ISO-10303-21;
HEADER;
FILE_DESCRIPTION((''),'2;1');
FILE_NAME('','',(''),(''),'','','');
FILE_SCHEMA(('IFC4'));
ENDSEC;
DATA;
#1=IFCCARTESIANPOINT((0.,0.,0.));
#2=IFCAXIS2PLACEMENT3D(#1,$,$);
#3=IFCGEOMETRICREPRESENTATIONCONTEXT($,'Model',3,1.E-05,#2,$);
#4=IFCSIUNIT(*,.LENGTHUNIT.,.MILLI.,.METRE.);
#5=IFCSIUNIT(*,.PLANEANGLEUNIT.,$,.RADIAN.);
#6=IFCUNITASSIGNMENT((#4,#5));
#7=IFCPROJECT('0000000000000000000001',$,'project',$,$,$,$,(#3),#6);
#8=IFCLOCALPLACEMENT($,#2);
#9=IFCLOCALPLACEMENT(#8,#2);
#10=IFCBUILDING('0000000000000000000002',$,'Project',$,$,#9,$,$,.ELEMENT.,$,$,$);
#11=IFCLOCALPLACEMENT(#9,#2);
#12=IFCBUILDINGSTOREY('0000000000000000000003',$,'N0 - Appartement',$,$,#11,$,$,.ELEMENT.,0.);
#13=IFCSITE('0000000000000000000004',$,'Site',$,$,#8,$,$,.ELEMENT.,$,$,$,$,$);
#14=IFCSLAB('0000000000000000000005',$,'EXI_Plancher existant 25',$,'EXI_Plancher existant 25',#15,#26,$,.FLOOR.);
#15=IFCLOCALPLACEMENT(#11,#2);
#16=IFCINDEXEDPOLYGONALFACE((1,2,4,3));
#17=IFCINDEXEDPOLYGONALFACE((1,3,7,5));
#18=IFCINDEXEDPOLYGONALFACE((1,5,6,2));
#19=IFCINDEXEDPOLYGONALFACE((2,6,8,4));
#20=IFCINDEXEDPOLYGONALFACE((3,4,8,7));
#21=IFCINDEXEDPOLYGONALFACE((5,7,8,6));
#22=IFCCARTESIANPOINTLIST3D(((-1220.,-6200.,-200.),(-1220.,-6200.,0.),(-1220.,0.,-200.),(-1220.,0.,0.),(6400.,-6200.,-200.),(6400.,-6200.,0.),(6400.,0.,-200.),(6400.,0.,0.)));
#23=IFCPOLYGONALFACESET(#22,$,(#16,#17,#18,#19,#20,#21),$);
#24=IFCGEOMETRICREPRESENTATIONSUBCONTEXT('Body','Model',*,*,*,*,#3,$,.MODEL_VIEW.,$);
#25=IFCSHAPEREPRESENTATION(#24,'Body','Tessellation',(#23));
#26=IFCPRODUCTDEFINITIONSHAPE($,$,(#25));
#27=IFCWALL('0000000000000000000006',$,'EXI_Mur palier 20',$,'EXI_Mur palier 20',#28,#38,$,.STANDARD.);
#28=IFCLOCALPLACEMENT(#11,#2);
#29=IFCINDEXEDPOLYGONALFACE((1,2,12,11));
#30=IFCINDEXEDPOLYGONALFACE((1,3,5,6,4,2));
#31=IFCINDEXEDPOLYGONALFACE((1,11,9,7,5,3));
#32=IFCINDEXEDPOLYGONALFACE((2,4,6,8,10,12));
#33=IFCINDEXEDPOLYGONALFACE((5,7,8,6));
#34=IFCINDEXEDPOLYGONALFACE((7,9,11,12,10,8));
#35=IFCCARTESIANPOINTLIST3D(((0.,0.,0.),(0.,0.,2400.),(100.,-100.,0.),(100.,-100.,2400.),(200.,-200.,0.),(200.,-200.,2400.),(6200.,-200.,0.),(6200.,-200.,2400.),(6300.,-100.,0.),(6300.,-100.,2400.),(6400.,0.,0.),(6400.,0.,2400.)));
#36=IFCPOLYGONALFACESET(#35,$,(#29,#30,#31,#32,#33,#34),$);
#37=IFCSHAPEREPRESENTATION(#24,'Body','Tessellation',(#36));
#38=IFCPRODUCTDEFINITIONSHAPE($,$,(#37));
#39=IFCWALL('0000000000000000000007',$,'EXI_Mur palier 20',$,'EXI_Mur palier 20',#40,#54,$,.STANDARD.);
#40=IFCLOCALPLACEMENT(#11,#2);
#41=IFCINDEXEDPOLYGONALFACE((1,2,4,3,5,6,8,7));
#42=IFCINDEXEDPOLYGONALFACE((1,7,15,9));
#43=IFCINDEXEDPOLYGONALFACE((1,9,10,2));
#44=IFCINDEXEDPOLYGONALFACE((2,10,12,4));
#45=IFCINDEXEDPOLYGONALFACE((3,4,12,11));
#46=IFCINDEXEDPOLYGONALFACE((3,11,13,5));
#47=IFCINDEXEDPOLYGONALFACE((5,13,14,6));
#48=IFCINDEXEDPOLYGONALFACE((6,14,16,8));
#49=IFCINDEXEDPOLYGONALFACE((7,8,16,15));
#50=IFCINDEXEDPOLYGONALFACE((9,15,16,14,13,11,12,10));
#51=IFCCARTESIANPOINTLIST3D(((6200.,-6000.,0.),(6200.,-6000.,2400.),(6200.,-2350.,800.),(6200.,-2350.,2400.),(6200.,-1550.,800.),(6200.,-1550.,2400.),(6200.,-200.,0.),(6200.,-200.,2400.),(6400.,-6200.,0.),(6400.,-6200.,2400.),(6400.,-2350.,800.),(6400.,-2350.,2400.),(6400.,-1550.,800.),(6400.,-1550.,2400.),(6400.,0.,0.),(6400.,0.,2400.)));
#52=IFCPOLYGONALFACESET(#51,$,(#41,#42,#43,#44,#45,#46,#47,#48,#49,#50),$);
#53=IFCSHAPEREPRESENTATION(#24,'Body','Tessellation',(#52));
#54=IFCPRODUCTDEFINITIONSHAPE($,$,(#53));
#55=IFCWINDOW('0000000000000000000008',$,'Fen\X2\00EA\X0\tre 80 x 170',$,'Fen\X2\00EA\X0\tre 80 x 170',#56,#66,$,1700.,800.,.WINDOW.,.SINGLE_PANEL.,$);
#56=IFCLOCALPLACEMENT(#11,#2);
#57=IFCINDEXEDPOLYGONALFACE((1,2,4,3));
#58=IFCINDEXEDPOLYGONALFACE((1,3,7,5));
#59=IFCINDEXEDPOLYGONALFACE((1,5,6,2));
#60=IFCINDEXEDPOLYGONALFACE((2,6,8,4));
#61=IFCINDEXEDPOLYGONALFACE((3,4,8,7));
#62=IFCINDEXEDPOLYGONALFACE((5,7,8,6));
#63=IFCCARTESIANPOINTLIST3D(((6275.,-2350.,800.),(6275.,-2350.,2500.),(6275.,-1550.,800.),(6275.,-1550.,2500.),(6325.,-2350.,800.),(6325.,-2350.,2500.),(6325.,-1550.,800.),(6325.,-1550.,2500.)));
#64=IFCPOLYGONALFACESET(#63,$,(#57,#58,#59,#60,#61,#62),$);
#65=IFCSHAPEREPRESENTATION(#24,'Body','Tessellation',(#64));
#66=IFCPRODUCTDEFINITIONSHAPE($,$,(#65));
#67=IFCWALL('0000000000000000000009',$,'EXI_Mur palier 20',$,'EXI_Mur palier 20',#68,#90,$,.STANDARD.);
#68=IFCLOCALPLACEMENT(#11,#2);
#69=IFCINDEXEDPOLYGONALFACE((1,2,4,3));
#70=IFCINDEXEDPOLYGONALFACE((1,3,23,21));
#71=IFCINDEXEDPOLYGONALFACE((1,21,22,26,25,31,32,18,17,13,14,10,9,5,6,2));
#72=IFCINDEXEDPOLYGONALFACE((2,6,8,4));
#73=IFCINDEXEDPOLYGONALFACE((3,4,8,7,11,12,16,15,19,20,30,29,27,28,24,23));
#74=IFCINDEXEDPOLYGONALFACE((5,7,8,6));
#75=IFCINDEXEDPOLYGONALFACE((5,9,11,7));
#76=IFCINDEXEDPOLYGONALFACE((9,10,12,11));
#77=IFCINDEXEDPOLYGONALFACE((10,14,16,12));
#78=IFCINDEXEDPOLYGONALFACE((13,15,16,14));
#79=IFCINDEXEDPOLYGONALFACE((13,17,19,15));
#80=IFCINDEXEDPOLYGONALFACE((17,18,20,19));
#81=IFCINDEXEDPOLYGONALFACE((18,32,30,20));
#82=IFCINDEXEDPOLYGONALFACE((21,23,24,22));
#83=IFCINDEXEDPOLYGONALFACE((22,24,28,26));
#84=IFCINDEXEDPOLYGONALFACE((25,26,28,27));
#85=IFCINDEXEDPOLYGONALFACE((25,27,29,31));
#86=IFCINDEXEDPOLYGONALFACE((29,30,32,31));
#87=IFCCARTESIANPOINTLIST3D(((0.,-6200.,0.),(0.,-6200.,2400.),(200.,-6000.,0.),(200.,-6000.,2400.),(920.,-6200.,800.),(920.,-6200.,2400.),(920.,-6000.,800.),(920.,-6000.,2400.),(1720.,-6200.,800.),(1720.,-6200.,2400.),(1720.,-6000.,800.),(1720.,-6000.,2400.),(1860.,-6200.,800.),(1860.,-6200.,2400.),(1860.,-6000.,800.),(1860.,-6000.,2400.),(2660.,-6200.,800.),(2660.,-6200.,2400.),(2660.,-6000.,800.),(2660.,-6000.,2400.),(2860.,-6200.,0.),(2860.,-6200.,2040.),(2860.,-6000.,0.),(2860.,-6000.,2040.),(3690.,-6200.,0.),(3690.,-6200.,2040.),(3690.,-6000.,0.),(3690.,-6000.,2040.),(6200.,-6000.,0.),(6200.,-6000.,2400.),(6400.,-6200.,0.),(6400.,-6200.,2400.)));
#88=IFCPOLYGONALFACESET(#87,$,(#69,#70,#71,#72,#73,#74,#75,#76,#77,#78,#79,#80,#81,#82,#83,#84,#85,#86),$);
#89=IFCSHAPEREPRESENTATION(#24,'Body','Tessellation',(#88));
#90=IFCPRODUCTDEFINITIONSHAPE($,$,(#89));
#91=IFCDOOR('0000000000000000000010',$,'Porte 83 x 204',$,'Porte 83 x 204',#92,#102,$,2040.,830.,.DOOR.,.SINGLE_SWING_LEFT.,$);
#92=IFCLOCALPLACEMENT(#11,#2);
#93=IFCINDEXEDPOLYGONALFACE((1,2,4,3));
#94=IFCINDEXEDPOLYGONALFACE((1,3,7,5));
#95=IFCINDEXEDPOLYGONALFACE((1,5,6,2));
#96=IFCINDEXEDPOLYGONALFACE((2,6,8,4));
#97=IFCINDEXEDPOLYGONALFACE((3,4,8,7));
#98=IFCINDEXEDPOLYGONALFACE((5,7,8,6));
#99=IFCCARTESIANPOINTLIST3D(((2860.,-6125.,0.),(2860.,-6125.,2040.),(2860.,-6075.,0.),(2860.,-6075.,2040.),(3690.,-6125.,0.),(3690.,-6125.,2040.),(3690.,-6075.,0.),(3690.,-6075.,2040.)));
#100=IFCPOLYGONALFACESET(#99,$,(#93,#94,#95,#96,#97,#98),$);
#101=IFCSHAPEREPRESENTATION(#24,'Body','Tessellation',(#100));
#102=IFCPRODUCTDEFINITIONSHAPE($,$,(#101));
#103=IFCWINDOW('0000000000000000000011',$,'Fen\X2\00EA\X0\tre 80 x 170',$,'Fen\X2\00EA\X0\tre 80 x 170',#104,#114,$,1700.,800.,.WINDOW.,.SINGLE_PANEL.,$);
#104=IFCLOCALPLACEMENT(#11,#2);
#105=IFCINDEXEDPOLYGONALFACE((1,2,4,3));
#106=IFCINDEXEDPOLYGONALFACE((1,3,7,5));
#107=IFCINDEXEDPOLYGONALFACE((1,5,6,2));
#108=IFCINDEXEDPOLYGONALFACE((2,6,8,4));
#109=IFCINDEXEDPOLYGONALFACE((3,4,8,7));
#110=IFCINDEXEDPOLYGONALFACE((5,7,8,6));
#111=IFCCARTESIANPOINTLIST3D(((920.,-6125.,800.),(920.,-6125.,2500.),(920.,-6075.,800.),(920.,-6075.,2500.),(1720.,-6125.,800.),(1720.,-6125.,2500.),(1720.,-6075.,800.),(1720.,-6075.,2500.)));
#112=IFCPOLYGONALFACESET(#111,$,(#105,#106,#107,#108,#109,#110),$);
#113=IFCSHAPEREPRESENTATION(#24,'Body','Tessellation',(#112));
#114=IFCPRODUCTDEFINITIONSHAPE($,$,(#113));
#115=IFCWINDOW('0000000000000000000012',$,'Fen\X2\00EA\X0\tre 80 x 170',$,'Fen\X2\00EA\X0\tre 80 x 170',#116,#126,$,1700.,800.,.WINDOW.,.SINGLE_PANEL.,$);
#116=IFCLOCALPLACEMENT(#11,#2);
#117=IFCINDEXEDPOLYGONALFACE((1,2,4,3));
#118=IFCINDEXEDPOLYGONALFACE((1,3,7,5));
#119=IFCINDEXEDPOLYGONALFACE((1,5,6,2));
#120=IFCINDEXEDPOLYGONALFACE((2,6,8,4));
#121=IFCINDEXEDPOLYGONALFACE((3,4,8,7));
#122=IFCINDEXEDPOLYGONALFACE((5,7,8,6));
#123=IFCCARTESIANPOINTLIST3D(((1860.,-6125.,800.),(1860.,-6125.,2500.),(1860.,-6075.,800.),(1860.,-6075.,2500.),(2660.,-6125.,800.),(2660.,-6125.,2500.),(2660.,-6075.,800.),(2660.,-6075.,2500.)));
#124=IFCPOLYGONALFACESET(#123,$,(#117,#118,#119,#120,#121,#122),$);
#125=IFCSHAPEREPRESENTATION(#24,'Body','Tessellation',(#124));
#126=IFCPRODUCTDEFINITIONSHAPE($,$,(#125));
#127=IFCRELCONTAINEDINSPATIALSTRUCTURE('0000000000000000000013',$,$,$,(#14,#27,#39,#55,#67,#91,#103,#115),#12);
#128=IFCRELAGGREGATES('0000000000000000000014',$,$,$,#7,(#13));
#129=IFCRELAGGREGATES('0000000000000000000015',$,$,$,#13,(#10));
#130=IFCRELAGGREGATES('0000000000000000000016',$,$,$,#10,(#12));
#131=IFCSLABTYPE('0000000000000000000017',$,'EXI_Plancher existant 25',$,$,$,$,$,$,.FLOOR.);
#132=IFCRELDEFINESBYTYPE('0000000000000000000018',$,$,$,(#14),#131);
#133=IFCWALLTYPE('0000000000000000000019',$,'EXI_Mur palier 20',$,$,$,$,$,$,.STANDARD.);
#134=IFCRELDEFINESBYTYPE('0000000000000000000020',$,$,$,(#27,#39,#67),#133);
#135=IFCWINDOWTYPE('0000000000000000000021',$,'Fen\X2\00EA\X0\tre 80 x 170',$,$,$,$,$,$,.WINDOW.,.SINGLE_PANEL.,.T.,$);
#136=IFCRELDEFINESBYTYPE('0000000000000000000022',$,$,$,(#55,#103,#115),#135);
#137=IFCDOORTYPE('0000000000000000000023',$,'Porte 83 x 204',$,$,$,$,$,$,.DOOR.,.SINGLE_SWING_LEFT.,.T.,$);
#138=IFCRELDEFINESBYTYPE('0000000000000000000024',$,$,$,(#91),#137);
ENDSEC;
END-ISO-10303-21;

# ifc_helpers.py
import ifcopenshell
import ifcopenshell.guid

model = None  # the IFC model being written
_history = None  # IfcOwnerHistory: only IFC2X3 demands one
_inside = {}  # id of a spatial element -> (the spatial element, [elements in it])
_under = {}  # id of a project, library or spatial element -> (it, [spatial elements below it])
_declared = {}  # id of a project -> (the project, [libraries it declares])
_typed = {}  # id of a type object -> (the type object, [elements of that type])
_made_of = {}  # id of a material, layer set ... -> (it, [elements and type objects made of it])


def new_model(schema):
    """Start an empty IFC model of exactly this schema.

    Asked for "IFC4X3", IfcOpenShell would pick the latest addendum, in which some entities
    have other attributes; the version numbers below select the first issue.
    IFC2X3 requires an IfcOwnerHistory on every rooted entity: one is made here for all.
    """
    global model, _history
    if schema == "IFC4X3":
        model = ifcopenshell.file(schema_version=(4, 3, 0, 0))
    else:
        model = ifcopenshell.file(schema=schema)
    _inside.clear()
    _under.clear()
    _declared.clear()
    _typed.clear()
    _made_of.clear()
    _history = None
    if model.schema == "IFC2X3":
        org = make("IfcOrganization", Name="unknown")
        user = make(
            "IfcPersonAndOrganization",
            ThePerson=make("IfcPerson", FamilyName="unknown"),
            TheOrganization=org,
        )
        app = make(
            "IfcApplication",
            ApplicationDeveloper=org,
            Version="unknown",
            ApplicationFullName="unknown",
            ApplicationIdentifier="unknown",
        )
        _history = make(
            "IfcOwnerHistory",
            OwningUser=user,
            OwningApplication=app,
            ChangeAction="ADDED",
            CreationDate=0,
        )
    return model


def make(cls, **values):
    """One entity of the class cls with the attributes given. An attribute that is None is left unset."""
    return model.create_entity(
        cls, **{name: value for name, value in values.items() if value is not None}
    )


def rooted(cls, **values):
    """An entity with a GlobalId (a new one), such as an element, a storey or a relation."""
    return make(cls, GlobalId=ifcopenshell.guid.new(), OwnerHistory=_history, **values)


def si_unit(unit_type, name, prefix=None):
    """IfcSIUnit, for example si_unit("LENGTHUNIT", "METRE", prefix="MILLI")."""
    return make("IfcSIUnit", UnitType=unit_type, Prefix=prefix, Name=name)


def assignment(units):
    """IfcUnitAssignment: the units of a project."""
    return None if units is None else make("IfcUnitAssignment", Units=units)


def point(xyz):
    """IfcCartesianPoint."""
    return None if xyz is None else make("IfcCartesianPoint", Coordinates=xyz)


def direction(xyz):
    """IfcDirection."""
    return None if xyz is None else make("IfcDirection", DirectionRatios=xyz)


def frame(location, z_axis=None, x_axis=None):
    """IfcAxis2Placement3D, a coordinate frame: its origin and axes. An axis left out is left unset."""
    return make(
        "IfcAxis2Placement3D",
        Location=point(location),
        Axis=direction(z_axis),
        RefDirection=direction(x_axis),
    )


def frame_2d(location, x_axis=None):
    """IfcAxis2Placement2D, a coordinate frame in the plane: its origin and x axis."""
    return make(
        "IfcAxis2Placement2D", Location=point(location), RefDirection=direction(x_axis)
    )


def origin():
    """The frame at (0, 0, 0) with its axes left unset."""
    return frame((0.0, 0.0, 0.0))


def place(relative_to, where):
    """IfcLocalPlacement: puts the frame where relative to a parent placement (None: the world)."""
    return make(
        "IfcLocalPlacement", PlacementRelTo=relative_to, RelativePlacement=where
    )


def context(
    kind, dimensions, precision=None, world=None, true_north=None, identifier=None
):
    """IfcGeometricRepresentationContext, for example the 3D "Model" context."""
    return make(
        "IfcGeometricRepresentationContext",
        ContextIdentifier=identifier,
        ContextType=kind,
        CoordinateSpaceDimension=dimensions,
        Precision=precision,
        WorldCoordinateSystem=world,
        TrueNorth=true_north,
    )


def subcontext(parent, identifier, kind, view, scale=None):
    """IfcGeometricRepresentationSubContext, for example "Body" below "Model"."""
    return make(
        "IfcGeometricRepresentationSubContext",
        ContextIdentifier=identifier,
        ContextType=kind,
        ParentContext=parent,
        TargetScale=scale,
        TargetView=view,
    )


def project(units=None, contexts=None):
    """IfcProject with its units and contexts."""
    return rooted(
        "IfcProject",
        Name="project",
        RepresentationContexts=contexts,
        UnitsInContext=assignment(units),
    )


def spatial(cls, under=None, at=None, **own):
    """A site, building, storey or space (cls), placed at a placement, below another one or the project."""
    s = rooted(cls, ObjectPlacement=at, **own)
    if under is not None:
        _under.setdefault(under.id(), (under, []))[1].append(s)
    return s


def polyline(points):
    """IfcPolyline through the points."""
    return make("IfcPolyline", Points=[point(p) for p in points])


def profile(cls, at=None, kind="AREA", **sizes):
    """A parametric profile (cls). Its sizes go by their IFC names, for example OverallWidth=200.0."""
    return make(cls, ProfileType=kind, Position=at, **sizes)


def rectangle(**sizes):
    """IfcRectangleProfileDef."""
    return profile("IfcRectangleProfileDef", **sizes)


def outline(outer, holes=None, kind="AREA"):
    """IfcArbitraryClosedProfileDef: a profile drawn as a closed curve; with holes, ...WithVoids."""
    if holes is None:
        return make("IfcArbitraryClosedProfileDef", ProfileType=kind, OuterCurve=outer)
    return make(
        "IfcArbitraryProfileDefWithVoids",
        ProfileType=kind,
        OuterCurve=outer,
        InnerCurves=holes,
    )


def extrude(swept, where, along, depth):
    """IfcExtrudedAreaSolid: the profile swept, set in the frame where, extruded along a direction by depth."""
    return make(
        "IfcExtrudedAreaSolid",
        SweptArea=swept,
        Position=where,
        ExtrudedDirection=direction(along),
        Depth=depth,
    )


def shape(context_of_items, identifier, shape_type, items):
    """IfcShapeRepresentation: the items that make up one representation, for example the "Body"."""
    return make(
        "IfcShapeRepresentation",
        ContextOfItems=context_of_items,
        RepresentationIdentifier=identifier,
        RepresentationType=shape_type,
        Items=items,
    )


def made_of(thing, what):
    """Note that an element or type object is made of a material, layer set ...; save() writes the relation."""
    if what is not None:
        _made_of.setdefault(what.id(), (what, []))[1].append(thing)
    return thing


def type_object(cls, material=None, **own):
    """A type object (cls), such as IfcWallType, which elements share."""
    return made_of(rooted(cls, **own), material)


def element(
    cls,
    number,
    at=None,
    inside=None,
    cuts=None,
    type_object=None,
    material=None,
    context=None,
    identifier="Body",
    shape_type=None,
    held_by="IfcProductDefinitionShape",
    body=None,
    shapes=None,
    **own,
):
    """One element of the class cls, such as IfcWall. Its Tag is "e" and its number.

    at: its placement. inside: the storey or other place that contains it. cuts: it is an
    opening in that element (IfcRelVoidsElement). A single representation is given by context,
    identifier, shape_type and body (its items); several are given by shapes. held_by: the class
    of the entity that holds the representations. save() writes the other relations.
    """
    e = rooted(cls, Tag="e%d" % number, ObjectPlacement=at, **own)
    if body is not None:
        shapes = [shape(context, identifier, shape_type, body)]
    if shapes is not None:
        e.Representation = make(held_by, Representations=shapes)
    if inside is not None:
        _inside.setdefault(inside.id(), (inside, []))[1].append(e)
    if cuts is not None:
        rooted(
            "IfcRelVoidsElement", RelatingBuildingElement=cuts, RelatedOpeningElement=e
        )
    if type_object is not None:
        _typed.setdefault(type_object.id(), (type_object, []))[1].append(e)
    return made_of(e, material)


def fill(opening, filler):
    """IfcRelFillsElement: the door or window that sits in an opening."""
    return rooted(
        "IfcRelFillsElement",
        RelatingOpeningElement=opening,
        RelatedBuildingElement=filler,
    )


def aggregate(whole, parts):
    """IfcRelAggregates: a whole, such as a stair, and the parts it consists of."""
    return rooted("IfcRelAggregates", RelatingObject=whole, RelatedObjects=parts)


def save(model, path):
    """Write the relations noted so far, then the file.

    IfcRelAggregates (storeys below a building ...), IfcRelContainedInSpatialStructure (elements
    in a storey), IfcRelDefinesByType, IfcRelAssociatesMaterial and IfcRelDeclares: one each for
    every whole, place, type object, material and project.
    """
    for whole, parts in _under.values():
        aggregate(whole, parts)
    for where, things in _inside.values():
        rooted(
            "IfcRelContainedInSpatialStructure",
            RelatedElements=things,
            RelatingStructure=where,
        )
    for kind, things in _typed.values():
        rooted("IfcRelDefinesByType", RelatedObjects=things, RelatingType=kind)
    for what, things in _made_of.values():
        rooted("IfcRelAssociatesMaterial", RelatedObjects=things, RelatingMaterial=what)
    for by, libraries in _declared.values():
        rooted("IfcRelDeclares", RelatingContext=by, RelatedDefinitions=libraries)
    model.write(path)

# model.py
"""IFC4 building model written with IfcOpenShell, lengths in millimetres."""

from ifc_helpers import new_model, si_unit, frame, frame_2d, origin, place, context, subcontext, project, spatial, polyline, rectangle, outline, extrude, type_object, element, fill, save


model = new_model("IFC4")

# Units and contexts
model_context = context("Model", 3, precision=1e-05, world=origin())
body_context = subcontext(model_context, "Body", "Model", "MODEL_VIEW")
ifc_project = project(units=[si_unit("LENGTHUNIT", "METRE", prefix="MILLI"), si_unit("PLANEANGLEUNIT", "RADIAN")], contexts=[model_context])

# Site, building, storey
site_placement = place(None, origin())
site = spatial("IfcSite", under=ifc_project, at=site_placement, Name="Site", CompositionType="ELEMENT")
building_placement = place(site_placement, origin())
building = spatial("IfcBuilding", under=site, at=building_placement, Name="Project", CompositionType="ELEMENT")
storey_placement = place(building_placement, origin())
storey = spatial("IfcBuildingStorey", under=building, at=storey_placement, Name="N0 - Appartement", CompositionType="ELEMENT", Elevation=0.0)

# Slab
slab_type = type_object("IfcSlabType", Name="EXI_Plancher existant 25", PredefinedType="FLOOR")
slab_placement = place(storey_placement, origin())
element("IfcSlab", 1, at=slab_placement, inside=storey, type_object=slab_type, Name="EXI_Plancher existant 25", ObjectType="EXI_Plancher existant 25", PredefinedType="FLOOR", context=body_context, shape_type="SweptSolid", body=[
    extrude(outline(polyline([(-1220.0, -6200.0), (6400.0, -6200.0), (6400.0, 0.0), (-1220.0, 0.0), (-1220.0, -6200.0)])), frame((0.0, 0.0, -200.0)), (0.0, 0.0, 1.0), 200.0),
])

# Wall
wall_type_1 = type_object("IfcWallType", Name="EXI_Mur palier 20", PredefinedType="STANDARD")
wall_1_placement = place(storey_placement, frame((100.0, -100.0, 0.0), z_axis=(0.0, 0.0, 1.0), x_axis=(1.0, 0.0, 0.0)))
element("IfcWall", 2, at=wall_1_placement, inside=storey, type_object=wall_type_1, Name="EXI_Mur palier 20", ObjectType="EXI_Mur palier 20", PredefinedType="STANDARD", context=body_context, shape_type="SweptSolid", body=[
    extrude(outline(polyline([(100.0, -100.0), (0.0, 0.0), (-100.0, 100.0), (6300.0, 100.0), (6200.0, 0.0), (6100.0, -100.0), (100.0, -100.0)])), origin(), (0.0, 0.0, 1.0), 2400.0),
])

# Wall, opening, window
wall_2_placement = place(storey_placement, frame((6300.0, -100.0, 0.0), z_axis=(0.0, 0.0, 1.0), x_axis=(0.0, -1.0, 0.0)))
wall_2 = element("IfcWall", 3, at=wall_2_placement, inside=storey, type_object=wall_type_1, Name="EXI_Mur palier 20", ObjectType="EXI_Mur palier 20", PredefinedType="STANDARD", context=body_context, shape_type="SweptSolid", body=[
    extrude(outline(polyline([(100.0, -100.0), (0.0, 0.0), (-100.0, 100.0), (6100.0, 100.0), (6000.0, 0.0), (5900.0, -100.0), (100.0, -100.0)])), origin(), (0.0, 0.0, 1.0), 2400.0),
])
opening_1_placement = place(wall_2_placement, frame((1450.0, 0.0, 800.0), z_axis=(0.0, 0.0, 1.0), x_axis=(1.0, 0.0, 0.0)))
opening_1 = element("IfcOpeningElement", 4, at=opening_1_placement, cuts=wall_2, PredefinedType="OPENING", context=body_context, shape_type="SweptSolid", body=[
    extrude(rectangle(XDim=800.0, YDim=220.0, at=frame_2d((400.0, 0.0))), origin(), (0.0, 0.0, 1.0), 1700.0),
])
window_type_1 = type_object("IfcWindowType", Name="Fenêtre 80 x 170", ParameterTakesPrecedence=True, PartitioningType="SINGLE_PANEL", PredefinedType="WINDOW")
window_1_placement = place(opening_1_placement, origin())
window_1 = element("IfcWindow", 5, at=window_1_placement, inside=storey, type_object=window_type_1, Name="Fenêtre 80 x 170", ObjectType="Fenêtre 80 x 170", OverallHeight=1700.0, OverallWidth=800.0, PartitioningType="SINGLE_PANEL", PredefinedType="WINDOW", context=body_context, shape_type="SweptSolid", body=[
    extrude(rectangle(XDim=800.0, YDim=50.0, at=frame_2d((400.0, 0.0))), origin(), (0.0, 0.0, 1.0), 1700.0),
])
fill(opening_1, window_1)

# Wall, openings, door, windows
wall_3_placement = place(storey_placement, frame((6300.0, -6100.0, 0.0), z_axis=(0.0, 0.0, 1.0), x_axis=(-1.0, 0.0, 0.0)))
wall_3 = element("IfcWall", 6, at=wall_3_placement, inside=storey, type_object=wall_type_1, Name="EXI_Mur palier 20", ObjectType="EXI_Mur palier 20", PredefinedType="STANDARD", context=body_context, shape_type="SweptSolid", body=[
    extrude(outline(polyline([(100.0, -100.0), (0.0, 0.0), (-100.0, 100.0), (6300.0, 100.0), (6200.0, 0.0), (6100.0, -100.0), (100.0, -100.0)])), origin(), (0.0, 0.0, 1.0), 2400.0),
])
opening_2_placement = place(wall_3_placement, frame((4580.0, 0.0, 800.0), z_axis=(0.0, 0.0, 1.0), x_axis=(1.0, 0.0, 0.0)))
opening_2 = element("IfcOpeningElement", 7, at=opening_2_placement, cuts=wall_3, PredefinedType="OPENING", context=body_context, shape_type="SweptSolid", body=[
    extrude(rectangle(XDim=800.0, YDim=220.0, at=frame_2d((400.0, 0.0))), origin(), (0.0, 0.0, 1.0), 1700.0),
])
opening_3_placement = place(wall_3_placement, frame((3640.0, 0.0, 800.0), z_axis=(0.0, 0.0, 1.0), x_axis=(1.0, 0.0, 0.0)))
opening_3 = element("IfcOpeningElement", 8, at=opening_3_placement, cuts=wall_3, PredefinedType="OPENING", context=body_context, shape_type="SweptSolid", body=[
    extrude(rectangle(XDim=800.0, YDim=220.0, at=frame_2d((400.0, 0.0))), origin(), (0.0, 0.0, 1.0), 1700.0),
])
opening_4_placement = place(wall_3_placement, frame((2610.0, 0.0, 0.0), z_axis=(0.0, 0.0, 1.0), x_axis=(1.0, 0.0, 0.0)))
opening_4 = element("IfcOpeningElement", 9, at=opening_4_placement, cuts=wall_3, PredefinedType="OPENING", context=body_context, shape_type="SweptSolid", body=[
    extrude(rectangle(XDim=830.0, YDim=220.0, at=frame_2d((415.0, 0.0))), origin(), (0.0, 0.0, 1.0), 2040.0),
])
door_type_1 = type_object("IfcDoorType", Name="Porte 83 x 204", OperationType="SINGLE_SWING_LEFT", ParameterTakesPrecedence=True, PredefinedType="DOOR")
door_1_placement = place(opening_4_placement, origin())
door_1 = element("IfcDoor", 10, at=door_1_placement, inside=storey, type_object=door_type_1, Name="Porte 83 x 204", ObjectType="Porte 83 x 204", OperationType="SINGLE_SWING_LEFT", OverallHeight=2040.0, OverallWidth=830.0, PredefinedType="DOOR", context=body_context, shape_type="SweptSolid", body=[
    extrude(rectangle(XDim=830.0, YDim=50.0, at=frame_2d((415.0, 0.0))), origin(), (0.0, 0.0, 1.0), 2040.0),
])
fill(opening_4, door_1)
window_2_placement = place(opening_2_placement, origin())
window_2 = element("IfcWindow", 11, at=window_2_placement, inside=storey, type_object=window_type_1, Name="Fenêtre 80 x 170", ObjectType="Fenêtre 80 x 170", OverallHeight=1700.0, OverallWidth=800.0, PartitioningType="SINGLE_PANEL", PredefinedType="WINDOW", context=body_context, shape_type="SweptSolid", body=[
    extrude(rectangle(XDim=800.0, YDim=50.0, at=frame_2d((400.0, 0.0))), origin(), (0.0, 0.0, 1.0), 1700.0),
])
fill(opening_2, window_2)
window_3_placement = place(opening_3_placement, origin())
window_3 = element("IfcWindow", 12, at=window_3_placement, inside=storey, type_object=window_type_1, Name="Fenêtre 80 x 170", ObjectType="Fenêtre 80 x 170", OverallHeight=1700.0, OverallWidth=800.0, PartitioningType="SINGLE_PANEL", PredefinedType="WINDOW", context=body_context, shape_type="SweptSolid", body=[
    extrude(rectangle(XDim=800.0, YDim=50.0, at=frame_2d((400.0, 0.0))), origin(), (0.0, 0.0, 1.0), 1700.0),
])
fill(opening_3, window_3)

save(model, "model.ifc")
